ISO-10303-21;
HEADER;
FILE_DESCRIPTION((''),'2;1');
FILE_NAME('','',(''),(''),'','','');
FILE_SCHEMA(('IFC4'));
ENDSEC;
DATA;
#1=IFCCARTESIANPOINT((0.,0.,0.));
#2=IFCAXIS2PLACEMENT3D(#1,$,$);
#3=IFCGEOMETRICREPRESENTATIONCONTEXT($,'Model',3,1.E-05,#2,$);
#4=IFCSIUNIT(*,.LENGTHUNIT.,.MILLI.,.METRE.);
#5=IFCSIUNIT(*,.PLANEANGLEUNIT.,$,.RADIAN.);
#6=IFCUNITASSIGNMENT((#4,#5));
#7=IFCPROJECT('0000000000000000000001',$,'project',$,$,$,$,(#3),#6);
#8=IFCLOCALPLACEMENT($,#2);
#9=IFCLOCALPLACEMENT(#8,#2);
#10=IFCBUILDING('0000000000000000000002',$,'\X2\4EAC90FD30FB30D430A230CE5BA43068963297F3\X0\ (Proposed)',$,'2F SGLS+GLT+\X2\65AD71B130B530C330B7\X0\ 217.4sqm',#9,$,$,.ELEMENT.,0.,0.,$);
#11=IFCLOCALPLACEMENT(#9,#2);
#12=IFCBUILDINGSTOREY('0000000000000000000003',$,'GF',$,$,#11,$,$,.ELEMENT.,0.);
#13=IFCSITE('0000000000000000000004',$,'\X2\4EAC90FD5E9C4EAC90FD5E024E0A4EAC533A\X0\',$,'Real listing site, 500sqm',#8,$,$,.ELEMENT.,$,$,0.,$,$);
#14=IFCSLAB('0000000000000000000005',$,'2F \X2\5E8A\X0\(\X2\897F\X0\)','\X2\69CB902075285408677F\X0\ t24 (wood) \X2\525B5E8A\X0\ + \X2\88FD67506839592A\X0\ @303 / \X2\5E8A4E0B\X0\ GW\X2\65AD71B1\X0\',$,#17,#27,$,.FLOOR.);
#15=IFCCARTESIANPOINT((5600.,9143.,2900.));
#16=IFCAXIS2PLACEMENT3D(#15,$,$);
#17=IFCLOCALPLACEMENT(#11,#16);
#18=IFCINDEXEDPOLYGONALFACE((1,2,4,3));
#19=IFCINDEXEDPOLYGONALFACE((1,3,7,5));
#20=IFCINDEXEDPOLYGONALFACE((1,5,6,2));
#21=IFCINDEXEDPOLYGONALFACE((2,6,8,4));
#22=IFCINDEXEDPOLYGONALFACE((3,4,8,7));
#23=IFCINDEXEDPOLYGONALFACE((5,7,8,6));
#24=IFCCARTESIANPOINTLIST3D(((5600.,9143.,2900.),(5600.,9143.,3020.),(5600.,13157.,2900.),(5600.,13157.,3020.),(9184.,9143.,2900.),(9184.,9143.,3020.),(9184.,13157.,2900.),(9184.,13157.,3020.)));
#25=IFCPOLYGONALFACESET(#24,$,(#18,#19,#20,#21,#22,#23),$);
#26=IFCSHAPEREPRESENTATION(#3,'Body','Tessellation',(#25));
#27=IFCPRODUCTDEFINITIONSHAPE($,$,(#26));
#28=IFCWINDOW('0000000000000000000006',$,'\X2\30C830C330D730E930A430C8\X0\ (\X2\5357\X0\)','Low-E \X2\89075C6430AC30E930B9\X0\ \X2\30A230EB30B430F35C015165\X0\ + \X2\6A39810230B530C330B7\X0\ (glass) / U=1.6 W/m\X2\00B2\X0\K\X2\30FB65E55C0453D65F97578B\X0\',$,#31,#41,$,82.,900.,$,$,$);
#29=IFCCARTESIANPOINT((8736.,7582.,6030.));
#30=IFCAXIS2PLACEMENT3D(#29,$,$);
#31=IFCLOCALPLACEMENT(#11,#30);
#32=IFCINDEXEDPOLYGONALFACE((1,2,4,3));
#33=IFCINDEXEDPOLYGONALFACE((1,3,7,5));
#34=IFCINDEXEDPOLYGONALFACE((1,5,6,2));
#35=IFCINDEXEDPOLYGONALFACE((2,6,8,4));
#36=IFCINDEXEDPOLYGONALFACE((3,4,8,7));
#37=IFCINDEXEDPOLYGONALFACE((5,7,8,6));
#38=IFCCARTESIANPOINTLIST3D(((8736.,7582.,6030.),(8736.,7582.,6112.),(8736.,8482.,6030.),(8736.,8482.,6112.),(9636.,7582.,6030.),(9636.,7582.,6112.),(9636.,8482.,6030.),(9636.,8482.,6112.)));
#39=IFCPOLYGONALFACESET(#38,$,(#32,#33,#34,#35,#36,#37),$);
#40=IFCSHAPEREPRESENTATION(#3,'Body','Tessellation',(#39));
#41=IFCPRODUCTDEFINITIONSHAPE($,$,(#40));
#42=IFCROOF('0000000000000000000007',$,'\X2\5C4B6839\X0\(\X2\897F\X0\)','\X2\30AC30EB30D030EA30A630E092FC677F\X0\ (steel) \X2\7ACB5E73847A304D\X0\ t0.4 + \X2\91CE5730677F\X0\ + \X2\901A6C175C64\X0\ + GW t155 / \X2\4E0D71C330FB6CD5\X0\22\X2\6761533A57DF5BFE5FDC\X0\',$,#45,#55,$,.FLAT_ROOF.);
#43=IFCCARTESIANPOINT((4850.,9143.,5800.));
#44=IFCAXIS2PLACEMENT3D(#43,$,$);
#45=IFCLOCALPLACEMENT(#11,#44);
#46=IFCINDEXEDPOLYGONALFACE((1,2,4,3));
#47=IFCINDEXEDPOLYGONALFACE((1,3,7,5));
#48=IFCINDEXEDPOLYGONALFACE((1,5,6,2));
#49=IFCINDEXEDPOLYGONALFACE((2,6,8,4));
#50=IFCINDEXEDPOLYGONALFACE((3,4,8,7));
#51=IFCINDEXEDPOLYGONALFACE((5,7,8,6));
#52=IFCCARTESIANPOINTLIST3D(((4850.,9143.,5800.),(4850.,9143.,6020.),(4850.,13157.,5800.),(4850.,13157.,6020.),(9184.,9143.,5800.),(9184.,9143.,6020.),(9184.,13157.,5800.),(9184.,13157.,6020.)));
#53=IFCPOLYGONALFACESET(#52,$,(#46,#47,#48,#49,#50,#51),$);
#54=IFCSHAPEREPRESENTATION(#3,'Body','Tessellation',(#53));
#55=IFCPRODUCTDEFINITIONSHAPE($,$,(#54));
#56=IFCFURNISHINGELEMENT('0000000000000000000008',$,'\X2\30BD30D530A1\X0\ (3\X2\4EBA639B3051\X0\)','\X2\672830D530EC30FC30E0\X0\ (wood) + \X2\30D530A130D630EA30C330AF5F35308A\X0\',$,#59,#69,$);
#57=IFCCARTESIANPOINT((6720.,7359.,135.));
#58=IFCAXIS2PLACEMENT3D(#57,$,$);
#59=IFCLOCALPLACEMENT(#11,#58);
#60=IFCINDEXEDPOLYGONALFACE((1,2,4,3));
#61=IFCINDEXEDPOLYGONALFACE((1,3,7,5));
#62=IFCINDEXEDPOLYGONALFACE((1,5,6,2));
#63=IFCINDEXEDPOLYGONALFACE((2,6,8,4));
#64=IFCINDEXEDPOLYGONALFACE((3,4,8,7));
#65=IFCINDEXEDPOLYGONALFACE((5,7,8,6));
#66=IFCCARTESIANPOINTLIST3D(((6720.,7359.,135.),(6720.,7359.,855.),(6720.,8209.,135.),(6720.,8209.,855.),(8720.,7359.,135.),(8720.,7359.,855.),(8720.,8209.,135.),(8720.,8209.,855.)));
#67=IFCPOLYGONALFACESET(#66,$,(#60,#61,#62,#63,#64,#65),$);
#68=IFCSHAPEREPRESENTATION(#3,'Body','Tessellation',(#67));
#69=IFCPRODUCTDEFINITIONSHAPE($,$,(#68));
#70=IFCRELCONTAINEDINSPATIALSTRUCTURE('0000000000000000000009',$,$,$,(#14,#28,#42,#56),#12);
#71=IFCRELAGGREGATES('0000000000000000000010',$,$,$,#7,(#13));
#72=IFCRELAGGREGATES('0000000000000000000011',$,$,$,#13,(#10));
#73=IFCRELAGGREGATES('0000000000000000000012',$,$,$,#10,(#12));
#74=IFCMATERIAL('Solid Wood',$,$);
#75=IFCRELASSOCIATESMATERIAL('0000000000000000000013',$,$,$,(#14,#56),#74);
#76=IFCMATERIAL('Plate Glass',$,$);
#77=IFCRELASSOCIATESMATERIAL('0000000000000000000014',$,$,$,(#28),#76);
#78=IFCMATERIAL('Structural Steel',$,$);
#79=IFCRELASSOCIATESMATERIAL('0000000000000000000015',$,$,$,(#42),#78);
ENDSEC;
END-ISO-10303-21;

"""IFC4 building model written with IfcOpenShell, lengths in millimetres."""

from ifc_helpers import new_model, si_unit, frame, frame_2d, origin, place, context, project, spatial, rectangle, extrude, material, element, save


model = new_model("IFC4")

# Units and contexts
model_context = context("Model", 3, precision=1e-05, world=origin())
ifc_project = project(units=[si_unit("LENGTHUNIT", "METRE", prefix="MILLI"), si_unit("PLANEANGLEUNIT", "RADIAN")], contexts=[model_context])

# Site, building, storey
site_placement = place(None, origin())
site = spatial("IfcSite", under=ifc_project, at=site_placement, Name="京都府京都市上京区", ObjectType="Real listing site, 500sqm", CompositionType="ELEMENT", RefElevation=0.0)
building_placement = place(site_placement, origin())
building = spatial("IfcBuilding", under=site, at=building_placement, Name="京都・ピアノ室と防音 (Proposed)", ObjectType="2F SGLS+GLT+断熱サッシ 217.4sqm", CompositionType="ELEMENT", ElevationOfRefHeight=0.0, ElevationOfTerrain=0.0)
storey_placement = place(building_placement, origin())
storey = spatial("IfcBuildingStorey", under=building, at=storey_placement, Name="GF", CompositionType="ELEMENT", Elevation=0.0)

# Shared definitions
ifc_material_1 = material(Name="Solid Wood")

# Slab
slab_1_placement = place(storey_placement, frame((5600.0, 9143.0, 2900.0)))
element("IfcSlab", 1, at=slab_1_placement, inside=storey, material=ifc_material_1, Name="2F 床(西)", Description="構造用合板 t24 (wood) 剛床 + 製材根太 @303 / 床下 GW断熱", PredefinedType="FLOOR", context=model_context, shape_type="SweptSolid", body=[
    extrude(rectangle(XDim=3584.0, YDim=4014.0, at=frame_2d((1792.0, 2007.0))), frame((5600.0, 9143.0, 2900.0)), (0.0, 0.0, 1.0), 120.0),
])

# Window
ifc_material_2 = material(Name="Plate Glass")
window_placement = place(storey_placement, frame((8736.0, 7582.0, 6030.0)))
element("IfcWindow", 2, at=window_placement, inside=storey, material=ifc_material_2, Name="トップライト (南)", Description="Low-E 複層ガラス アルゴン封入 + 樹脂サッシ (glass) / U=1.6 W/m²K・日射取得型", OverallHeight=82.0, OverallWidth=900.0, context=model_context, shape_type="SweptSolid", body=[
    extrude(rectangle(XDim=900.0, YDim=900.0, at=frame_2d((450.0, 450.0))), frame((8736.0, 7582.0, 6030.0)), (0.0, 0.0, 1.0), 82.0),
])

# Roof
ifc_material_3 = material(Name="Structural Steel")
for number, where, name in (
    (3, (4850.0, 9143.0, 5800.0), "屋根(西)"),
):
    element("IfcRoof", number, at=place(storey_placement, frame(where)), inside=storey, material=ifc_material_3, Name=name, Description="ガルバリウム鋼板 (steel) 立平葺き t0.4 + 野地板 + 通気層 + GW t155 / 不燃・法22条区域対応", PredefinedType="FLAT_ROOF", context=model_context, shape_type="SweptSolid", body=[
        extrude(rectangle(XDim=4334.0, YDim=4014.0, at=frame_2d((2167.0, 2007.0))), frame((4850.0, 9143.0, 5800.0)), (0.0, 0.0, 1.0), 220.0),
    ])

# Furnishing element
furnishing_placement = place(storey_placement, frame((6720.0, 7359.0, 135.0)))
element("IfcFurnishingElement", 4, at=furnishing_placement, inside=storey, material=ifc_material_1, Name="ソファ (3人掛け)", Description="木フレーム (wood) + ファブリック張り", context=model_context, shape_type="SweptSolid", body=[
    extrude(rectangle(XDim=2000.0, YDim=850.0, at=frame_2d((1000.0, 425.0))), frame((6720.0, 7359.0, 135.0)), (0.0, 0.0, 1.0), 720.0),
])

save(model, "model.ifc")
